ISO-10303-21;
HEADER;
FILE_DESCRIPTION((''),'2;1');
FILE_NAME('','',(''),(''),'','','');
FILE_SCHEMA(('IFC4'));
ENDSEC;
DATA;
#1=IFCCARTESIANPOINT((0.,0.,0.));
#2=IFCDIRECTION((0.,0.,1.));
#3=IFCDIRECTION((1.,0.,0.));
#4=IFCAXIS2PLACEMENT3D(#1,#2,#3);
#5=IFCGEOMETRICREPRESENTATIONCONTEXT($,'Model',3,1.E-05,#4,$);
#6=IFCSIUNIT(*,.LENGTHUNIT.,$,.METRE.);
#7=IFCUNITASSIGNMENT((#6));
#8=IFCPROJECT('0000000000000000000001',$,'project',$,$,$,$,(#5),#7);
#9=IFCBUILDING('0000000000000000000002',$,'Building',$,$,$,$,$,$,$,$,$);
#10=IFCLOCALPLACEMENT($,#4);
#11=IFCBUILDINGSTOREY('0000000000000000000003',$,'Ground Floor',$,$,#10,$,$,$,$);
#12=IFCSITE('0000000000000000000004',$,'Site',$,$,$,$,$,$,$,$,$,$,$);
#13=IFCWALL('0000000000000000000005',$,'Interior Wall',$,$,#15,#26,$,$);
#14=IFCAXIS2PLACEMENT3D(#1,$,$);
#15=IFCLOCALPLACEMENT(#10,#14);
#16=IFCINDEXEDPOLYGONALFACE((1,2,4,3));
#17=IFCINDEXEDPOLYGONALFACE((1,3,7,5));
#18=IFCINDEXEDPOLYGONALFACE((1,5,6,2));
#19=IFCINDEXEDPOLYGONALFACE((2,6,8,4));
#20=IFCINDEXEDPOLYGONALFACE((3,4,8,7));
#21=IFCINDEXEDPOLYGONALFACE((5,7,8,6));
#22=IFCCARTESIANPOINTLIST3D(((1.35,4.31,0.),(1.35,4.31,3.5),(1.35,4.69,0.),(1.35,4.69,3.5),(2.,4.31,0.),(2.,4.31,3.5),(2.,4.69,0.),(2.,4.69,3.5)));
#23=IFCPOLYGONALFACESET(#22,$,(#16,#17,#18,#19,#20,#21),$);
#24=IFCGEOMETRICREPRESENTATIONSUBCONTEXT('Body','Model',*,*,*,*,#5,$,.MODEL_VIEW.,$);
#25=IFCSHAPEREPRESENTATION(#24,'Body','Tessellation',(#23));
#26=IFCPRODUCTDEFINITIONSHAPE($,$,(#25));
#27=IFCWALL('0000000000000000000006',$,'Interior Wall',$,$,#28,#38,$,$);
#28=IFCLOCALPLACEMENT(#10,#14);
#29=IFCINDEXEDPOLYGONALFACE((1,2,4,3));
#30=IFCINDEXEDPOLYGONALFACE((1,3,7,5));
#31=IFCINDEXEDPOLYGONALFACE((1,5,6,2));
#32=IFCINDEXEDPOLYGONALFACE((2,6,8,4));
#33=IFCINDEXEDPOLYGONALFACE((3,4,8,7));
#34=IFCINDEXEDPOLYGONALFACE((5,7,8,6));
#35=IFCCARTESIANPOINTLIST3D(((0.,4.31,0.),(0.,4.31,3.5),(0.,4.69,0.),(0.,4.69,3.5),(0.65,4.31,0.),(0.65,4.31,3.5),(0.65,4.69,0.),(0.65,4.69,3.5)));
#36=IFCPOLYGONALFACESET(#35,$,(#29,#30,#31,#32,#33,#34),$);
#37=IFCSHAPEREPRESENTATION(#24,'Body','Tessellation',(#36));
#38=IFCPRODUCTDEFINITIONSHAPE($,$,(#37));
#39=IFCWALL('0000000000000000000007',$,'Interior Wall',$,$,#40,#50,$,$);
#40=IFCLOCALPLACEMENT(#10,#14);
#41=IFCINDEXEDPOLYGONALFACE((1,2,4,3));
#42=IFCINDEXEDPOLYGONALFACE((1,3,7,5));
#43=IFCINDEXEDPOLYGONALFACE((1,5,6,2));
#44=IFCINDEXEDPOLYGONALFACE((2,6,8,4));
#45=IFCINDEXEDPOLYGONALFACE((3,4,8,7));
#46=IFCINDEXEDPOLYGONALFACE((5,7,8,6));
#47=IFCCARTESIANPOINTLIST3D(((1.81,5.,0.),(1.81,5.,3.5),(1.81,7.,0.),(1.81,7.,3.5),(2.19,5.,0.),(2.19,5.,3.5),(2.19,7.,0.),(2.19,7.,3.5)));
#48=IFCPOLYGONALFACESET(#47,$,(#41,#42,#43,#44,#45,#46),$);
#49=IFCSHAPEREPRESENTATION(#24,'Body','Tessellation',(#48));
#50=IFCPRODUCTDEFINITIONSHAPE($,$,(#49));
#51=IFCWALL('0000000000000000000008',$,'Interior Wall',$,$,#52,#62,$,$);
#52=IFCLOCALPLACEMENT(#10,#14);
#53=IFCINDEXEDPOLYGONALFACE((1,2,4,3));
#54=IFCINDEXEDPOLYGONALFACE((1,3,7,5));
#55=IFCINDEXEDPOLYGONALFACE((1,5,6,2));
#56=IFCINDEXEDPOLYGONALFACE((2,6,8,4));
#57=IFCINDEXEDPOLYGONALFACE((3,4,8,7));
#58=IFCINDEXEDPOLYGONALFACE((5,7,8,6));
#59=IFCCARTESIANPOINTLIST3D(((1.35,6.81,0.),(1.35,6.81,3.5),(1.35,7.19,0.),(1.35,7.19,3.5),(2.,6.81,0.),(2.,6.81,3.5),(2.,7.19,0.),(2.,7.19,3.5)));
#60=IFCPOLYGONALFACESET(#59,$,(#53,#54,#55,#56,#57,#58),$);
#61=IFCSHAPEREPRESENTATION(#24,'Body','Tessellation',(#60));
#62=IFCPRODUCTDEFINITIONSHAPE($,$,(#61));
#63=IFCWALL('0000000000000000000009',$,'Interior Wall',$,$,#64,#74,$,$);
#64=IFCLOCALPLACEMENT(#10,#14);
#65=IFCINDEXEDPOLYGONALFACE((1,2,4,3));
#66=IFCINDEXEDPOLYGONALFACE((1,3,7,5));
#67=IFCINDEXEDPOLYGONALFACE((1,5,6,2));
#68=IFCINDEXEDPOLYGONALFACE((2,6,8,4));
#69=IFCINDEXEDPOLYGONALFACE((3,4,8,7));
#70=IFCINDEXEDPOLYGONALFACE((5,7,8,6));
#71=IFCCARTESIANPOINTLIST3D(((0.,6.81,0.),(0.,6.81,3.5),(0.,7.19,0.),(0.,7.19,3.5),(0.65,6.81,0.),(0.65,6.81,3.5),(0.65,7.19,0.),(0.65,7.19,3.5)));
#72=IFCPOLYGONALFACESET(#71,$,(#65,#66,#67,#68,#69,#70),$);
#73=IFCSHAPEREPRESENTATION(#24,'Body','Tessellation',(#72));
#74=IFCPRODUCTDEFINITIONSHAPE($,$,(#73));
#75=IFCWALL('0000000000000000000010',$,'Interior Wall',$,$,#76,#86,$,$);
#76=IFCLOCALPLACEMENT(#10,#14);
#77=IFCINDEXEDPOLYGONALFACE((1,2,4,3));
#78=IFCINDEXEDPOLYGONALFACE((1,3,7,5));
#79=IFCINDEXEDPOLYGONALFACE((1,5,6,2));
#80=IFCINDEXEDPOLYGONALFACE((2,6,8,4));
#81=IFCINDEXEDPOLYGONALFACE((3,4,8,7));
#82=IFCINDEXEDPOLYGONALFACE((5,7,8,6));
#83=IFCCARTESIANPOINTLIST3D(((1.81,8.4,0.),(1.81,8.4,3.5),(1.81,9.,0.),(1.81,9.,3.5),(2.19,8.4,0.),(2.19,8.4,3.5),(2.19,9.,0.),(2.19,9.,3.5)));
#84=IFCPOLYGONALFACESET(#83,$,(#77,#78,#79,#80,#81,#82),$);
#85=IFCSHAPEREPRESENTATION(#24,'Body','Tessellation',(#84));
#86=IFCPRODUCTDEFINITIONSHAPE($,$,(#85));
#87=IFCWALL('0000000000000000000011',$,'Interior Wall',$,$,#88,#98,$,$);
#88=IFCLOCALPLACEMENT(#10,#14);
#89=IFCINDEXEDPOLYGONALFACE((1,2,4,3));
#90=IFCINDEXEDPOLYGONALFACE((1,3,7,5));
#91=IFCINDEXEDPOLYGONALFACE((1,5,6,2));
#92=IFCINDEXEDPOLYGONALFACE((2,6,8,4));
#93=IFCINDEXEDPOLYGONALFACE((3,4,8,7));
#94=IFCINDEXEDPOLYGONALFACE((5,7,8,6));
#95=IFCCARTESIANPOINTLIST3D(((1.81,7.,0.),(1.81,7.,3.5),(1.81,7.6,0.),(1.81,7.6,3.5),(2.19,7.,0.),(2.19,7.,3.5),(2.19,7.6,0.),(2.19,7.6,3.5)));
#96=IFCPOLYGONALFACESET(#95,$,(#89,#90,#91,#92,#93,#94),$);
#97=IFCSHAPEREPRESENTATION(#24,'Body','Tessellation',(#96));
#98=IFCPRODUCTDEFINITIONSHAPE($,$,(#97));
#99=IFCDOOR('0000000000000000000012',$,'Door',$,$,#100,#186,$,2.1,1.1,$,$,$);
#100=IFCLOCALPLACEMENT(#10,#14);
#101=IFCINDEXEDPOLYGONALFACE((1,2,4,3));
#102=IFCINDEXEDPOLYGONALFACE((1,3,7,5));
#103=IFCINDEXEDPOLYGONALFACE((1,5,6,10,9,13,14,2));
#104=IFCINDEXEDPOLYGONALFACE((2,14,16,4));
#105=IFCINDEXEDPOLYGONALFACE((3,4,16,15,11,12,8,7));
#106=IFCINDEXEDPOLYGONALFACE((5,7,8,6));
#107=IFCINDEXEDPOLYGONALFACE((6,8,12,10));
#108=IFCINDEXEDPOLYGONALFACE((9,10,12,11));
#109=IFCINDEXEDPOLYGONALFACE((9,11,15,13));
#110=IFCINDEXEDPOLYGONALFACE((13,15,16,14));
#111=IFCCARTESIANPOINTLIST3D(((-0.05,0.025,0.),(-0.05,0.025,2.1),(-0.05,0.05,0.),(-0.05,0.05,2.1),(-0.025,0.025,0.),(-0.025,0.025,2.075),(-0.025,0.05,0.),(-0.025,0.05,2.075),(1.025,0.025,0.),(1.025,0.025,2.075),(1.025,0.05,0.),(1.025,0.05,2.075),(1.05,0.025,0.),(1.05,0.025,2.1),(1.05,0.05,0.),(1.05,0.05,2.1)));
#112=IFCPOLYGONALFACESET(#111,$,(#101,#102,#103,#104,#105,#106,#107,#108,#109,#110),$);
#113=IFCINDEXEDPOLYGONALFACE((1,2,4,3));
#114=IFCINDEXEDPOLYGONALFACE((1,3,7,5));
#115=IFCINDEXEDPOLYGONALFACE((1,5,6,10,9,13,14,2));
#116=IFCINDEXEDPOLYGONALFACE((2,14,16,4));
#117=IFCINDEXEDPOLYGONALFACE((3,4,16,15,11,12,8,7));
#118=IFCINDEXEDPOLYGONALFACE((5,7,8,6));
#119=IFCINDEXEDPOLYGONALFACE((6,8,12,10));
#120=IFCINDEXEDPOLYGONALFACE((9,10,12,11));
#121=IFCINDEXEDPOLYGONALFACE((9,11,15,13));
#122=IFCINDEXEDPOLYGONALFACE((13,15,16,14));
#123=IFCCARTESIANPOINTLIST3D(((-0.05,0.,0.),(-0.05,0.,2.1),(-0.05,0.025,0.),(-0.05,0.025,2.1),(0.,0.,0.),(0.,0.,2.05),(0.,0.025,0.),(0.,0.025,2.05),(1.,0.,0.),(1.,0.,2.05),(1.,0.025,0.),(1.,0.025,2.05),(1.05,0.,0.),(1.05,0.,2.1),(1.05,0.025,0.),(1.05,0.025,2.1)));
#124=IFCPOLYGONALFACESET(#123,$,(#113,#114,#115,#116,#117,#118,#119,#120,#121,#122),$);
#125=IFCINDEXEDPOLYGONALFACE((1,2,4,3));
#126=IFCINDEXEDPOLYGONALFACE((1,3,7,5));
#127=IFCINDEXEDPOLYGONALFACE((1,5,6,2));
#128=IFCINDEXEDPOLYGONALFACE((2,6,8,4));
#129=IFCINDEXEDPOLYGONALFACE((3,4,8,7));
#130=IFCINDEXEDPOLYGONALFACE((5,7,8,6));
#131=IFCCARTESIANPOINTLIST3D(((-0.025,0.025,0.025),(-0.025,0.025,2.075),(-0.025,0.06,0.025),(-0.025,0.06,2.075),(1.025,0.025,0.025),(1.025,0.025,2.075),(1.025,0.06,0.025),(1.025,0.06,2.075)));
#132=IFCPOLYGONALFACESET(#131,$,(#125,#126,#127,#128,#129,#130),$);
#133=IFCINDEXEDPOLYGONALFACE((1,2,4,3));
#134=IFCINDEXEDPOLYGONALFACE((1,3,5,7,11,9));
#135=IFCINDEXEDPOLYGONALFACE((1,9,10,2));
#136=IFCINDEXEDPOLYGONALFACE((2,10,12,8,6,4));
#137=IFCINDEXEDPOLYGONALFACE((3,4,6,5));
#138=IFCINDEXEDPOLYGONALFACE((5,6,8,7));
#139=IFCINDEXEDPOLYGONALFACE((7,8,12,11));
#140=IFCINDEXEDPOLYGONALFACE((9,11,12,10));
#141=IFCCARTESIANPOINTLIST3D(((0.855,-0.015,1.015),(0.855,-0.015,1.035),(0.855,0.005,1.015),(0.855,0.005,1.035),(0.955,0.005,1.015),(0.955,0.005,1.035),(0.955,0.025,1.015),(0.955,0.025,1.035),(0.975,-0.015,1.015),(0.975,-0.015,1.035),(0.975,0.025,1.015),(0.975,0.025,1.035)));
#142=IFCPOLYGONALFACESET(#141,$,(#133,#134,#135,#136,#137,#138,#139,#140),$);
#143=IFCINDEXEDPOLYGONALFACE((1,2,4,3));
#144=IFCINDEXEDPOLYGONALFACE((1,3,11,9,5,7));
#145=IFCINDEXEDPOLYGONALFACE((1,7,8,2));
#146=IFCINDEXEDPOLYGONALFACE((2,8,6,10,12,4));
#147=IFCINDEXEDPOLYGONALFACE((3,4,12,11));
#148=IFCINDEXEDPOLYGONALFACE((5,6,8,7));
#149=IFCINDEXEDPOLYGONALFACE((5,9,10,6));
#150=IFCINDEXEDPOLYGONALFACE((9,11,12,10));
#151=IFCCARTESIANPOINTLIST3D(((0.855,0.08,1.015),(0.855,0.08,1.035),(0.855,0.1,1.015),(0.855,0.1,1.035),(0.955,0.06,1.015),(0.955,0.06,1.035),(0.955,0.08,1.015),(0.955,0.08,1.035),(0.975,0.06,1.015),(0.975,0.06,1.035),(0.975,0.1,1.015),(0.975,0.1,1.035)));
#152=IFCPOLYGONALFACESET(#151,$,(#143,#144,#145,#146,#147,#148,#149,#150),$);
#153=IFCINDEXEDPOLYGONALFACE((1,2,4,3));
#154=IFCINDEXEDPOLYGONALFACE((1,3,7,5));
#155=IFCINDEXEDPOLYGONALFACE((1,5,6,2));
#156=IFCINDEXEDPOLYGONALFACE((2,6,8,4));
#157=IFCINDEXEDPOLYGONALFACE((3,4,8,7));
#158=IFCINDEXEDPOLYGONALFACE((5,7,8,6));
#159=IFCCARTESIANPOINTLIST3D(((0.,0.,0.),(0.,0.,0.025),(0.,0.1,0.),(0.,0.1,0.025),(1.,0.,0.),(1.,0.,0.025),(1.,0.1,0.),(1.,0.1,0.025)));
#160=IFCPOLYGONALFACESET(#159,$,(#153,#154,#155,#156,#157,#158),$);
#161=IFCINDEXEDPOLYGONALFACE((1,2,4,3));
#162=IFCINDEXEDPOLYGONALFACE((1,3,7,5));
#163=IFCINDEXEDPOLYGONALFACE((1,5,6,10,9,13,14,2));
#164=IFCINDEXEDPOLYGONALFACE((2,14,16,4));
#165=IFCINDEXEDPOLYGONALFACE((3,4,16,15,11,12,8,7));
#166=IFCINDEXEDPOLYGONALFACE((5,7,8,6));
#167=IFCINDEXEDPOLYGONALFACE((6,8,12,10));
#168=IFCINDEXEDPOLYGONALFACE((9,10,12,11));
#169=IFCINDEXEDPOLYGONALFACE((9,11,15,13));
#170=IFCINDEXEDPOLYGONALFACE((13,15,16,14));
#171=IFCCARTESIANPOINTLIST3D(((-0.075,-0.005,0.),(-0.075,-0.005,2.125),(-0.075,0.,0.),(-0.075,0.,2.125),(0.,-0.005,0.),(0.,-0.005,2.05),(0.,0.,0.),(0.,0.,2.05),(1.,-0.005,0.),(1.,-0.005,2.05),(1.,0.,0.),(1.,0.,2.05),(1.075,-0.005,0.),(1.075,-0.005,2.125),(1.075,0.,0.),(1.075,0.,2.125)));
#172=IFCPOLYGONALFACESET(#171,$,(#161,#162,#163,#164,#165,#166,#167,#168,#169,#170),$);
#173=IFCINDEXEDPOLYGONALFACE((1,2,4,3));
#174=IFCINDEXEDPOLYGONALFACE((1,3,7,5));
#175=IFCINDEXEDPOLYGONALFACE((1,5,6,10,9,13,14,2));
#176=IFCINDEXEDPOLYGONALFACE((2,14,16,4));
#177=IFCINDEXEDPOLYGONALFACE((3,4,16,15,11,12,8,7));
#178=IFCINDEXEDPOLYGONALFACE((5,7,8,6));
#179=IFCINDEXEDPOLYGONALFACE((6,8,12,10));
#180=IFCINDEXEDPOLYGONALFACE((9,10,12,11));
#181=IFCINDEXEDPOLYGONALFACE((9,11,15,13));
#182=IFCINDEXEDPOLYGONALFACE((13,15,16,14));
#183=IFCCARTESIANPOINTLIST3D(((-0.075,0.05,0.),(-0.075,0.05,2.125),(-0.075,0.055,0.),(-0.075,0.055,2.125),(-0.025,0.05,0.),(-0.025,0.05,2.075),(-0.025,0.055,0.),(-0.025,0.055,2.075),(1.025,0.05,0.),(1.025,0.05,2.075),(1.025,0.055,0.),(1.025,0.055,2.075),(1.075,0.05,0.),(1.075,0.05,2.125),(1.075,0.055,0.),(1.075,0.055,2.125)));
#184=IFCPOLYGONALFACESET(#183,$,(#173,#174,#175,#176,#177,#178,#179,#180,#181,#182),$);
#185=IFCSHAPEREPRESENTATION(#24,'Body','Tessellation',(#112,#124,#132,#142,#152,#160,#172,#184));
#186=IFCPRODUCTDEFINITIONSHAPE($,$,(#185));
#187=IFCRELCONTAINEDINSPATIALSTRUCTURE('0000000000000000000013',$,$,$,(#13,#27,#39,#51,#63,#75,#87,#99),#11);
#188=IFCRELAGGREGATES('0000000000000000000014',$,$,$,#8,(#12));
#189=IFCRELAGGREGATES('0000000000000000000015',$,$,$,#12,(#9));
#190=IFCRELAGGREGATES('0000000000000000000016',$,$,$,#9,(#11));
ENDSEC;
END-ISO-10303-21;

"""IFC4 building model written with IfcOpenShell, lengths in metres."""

from ifc_helpers import new_model, si_unit, frame, origin_with_axes, place, context, subcontext, project, spatial, line, indexed_curve, outline, extrude, element, save


model = new_model("IFC4")

# Units and contexts
model_context = context("Model", 3, precision=1e-05, world=origin_with_axes())
body_context = subcontext(model_context, "Body", "Model", "MODEL_VIEW")
ifc_project = project(units=[si_unit("LENGTHUNIT", "METRE")], contexts=[model_context])

# Site, building, storey
site = spatial("IfcSite", under=ifc_project, Name="Site")
building = spatial("IfcBuilding", under=site, Name="Building")
storey_placement = place(None, origin_with_axes())
storey = spatial("IfcBuildingStorey", under=building, at=storey_placement, Name="Ground Floor")

# Walls
for number, where, z_axis, x_axis, name in (
    (1, (2.0, 4.5, 0.0), (0.0, 0.0, 1.0), (-1.0, 0.0, 0.0), "Interior Wall"),
    (2, (0.65, 4.5, 0.0), (0.0, 0.0, 1.0), (-1.0, 0.0, 0.0), "Interior Wall"),
):
    element("IfcWall", number, at=place(storey_placement, frame(where, z_axis=z_axis, x_axis=x_axis)), inside=storey, Name=name, context=body_context, shape_type="SweptSolid", body=[
        extrude(outline(indexed_curve([(0.0, 0.0), (0.0, 0.38), (0.65, 0.38), (0.65, 0.0), (0.0, 0.0)], self_intersect=False)), frame((0.0, -0.19, 0.0), z_axis=(0.0, 0.0, 1.0), x_axis=(1.0, 0.0, 0.0)), (0.0, 0.0, 1.0), 3.5),
    ])
wall_1_placement = place(storey_placement, frame((2.0, 5.0, 0.0), z_axis=(0.0, 0.0, 1.0), x_axis=(0.0, 1.0, 0.0)))
element("IfcWall", 3, at=wall_1_placement, inside=storey, Name="Interior Wall", context=body_context, shape_type="SweptSolid", body=[
    extrude(outline(indexed_curve([(0.0, 0.0), (0.0, 0.38), (2.0, 0.38), (2.0, 0.0), (0.0, 0.0)], self_intersect=False)), frame((0.0, -0.19, 0.0), z_axis=(0.0, 0.0, 1.0), x_axis=(1.0, 0.0, 0.0)), (0.0, 0.0, 1.0), 3.5),
])
for number, where, z_axis, x_axis, name in (
    (4, (2.0, 7.0, 0.0), (0.0, 0.0, 1.0), (-1.0, 0.0, 0.0), "Interior Wall"),
    (5, (0.65, 7.0, 0.0), (0.0, 0.0, 1.0), (-1.0, 0.0, 0.0), "Interior Wall"),
):
    element("IfcWall", number, at=place(storey_placement, frame(where, z_axis=z_axis, x_axis=x_axis)), inside=storey, Name=name, context=body_context, shape_type="SweptSolid", body=[
        extrude(outline(indexed_curve([(0.0, 0.0), (0.0, 0.38), (0.65, 0.38), (0.65, 0.0), (0.0, 0.0)], self_intersect=False)), frame((0.0, -0.19, 0.0), z_axis=(0.0, 0.0, 1.0), x_axis=(1.0, 0.0, 0.0)), (0.0, 0.0, 1.0), 3.5),
    ])
for number, where, z_axis, x_axis, name in (
    (6, (2.0, 9.0, 0.0), (0.0, 0.0, 1.0), (0.0, -1.0, 0.0), "Interior Wall"),
    (7, (2.0, 7.6, 0.0), (0.0, 0.0, 1.0), (0.0, -1.0, 0.0), "Interior Wall"),
):
    element("IfcWall", number, at=place(storey_placement, frame(where, z_axis=z_axis, x_axis=x_axis)), inside=storey, Name=name, context=body_context, shape_type="SweptSolid", body=[
        extrude(outline(indexed_curve([(0.0, 0.0), (0.0, 0.38), (0.6, 0.38), (0.6, 0.0), (0.0, 0.0)], self_intersect=False)), frame((0.0, -0.19, 0.0), z_axis=(0.0, 0.0, 1.0), x_axis=(1.0, 0.0, 0.0)), (0.0, 0.0, 1.0), 3.5),
    ])

# Door
door_1_placement = place(storey_placement, frame((-0.05, 0.0, 0.0), z_axis=(0.0, 0.0, 1.0), x_axis=(1.0, 0.0, 0.0)))
element("IfcDoor", 8, at=door_1_placement, inside=storey, Name="Door", OverallHeight=2.1, OverallWidth=1.1, context=body_context, shape_type="SweptSolid", body=[
    extrude(outline(indexed_curve([(0.0, 0.0), (0.0, 2.1), (1.1, 2.1), (1.1, 0.0), (1.075, 0.0), (1.075, 2.075), (0.025, 2.075), (0.025, 0.0)], segments=[line(1, 2, 3, 4, 5, 6, 7, 8, 1)])), frame((0.0, 0.025, 0.0), z_axis=(0.0, -1.0, 0.0), x_axis=(1.0, 0.0, 0.0)), (0.0, 0.0, -1.0), 0.025),
    extrude(outline(indexed_curve([(0.0, 0.0), (0.0, 2.1), (1.1, 2.1), (1.1, 0.0), (1.05, 0.0), (1.05, 2.05), (0.05, 2.05), (0.05, 0.0)], segments=[line(1, 2, 3, 4, 5, 6, 7, 8, 1)])), frame((0.0, 0.0, 0.0), z_axis=(0.0, -1.0, 0.0), x_axis=(1.0, 0.0, 0.0)), (0.0, 0.0, -1.0), 0.025),
    extrude(outline(indexed_curve([(0.0, 0.0), (1.05, 0.0), (1.05, 0.035), (0.0, 0.035)], segments=[line(1, 2, 3, 4, 1)])), frame((0.025, 0.025, 0.025), z_axis=(0.0, 0.0, 1.0), x_axis=(1.0, 0.0, 0.0)), (0.0, 0.0, 1.0), 2.05),
    extrude(outline(indexed_curve([(0.0, 0.0), (0.0, -0.04), (-0.12, -0.04), (-0.12, -0.02), (-0.02, -0.02), (-0.02, 0.0)], segments=[line(1, 2, 3, 4, 5, 6, 1)])), frame((1.025, 0.025, 1.015), z_axis=(0.0, 0.0, 1.0), x_axis=(1.0, 0.0, 0.0)), (0.0, 0.0, 1.0), 0.02),
    extrude(outline(indexed_curve([(0.0, 0.0), (0.0, 0.04), (-0.12, 0.04), (-0.12, 0.02), (-0.02, 0.02), (-0.02, 0.0)], segments=[line(1, 2, 3, 4, 5, 6, 1)])), frame((1.025, 0.06, 1.015), z_axis=(0.0, 0.0, 1.0), x_axis=(1.0, 0.0, 0.0)), (0.0, 0.0, 1.0), 0.02),
    extrude(outline(indexed_curve([(0.0, 0.0), (1.0, 0.0), (1.0, 0.1), (0.0, 0.1)], segments=[line(1, 2, 3, 4, 1)])), frame((0.05, 0.0, 0.0), z_axis=(0.0, 0.0, 1.0), x_axis=(1.0, 0.0, 0.0)), (0.0, 0.0, 1.0), 0.025),
    extrude(outline(indexed_curve([(0.0, 0.0), (0.0, 2.125), (1.15, 2.125), (1.15, 0.0), (1.075, 0.0), (1.075, 2.05), (0.075, 2.05), (0.075, 0.0)], segments=[line(1, 2, 3, 4, 5, 6, 7, 8, 1)])), frame((-0.025, -0.005, 0.0), z_axis=(0.0, -1.0, 0.0), x_axis=(1.0, 0.0, 0.0)), (0.0, 0.0, -1.0), 0.005),
    extrude(outline(indexed_curve([(0.0, 0.0), (0.0, 2.125), (1.15, 2.125), (1.15, 0.0), (1.1, 0.0), (1.1, 2.075), (0.05, 2.075), (0.05, 0.0)], segments=[line(1, 2, 3, 4, 5, 6, 7, 8, 1)])), frame((-0.025, 0.05, 0.0), z_axis=(0.0, -1.0, 0.0), x_axis=(1.0, 0.0, 0.0)), (0.0, 0.0, -1.0), 0.005),
])

save(model, "model.ifc")
